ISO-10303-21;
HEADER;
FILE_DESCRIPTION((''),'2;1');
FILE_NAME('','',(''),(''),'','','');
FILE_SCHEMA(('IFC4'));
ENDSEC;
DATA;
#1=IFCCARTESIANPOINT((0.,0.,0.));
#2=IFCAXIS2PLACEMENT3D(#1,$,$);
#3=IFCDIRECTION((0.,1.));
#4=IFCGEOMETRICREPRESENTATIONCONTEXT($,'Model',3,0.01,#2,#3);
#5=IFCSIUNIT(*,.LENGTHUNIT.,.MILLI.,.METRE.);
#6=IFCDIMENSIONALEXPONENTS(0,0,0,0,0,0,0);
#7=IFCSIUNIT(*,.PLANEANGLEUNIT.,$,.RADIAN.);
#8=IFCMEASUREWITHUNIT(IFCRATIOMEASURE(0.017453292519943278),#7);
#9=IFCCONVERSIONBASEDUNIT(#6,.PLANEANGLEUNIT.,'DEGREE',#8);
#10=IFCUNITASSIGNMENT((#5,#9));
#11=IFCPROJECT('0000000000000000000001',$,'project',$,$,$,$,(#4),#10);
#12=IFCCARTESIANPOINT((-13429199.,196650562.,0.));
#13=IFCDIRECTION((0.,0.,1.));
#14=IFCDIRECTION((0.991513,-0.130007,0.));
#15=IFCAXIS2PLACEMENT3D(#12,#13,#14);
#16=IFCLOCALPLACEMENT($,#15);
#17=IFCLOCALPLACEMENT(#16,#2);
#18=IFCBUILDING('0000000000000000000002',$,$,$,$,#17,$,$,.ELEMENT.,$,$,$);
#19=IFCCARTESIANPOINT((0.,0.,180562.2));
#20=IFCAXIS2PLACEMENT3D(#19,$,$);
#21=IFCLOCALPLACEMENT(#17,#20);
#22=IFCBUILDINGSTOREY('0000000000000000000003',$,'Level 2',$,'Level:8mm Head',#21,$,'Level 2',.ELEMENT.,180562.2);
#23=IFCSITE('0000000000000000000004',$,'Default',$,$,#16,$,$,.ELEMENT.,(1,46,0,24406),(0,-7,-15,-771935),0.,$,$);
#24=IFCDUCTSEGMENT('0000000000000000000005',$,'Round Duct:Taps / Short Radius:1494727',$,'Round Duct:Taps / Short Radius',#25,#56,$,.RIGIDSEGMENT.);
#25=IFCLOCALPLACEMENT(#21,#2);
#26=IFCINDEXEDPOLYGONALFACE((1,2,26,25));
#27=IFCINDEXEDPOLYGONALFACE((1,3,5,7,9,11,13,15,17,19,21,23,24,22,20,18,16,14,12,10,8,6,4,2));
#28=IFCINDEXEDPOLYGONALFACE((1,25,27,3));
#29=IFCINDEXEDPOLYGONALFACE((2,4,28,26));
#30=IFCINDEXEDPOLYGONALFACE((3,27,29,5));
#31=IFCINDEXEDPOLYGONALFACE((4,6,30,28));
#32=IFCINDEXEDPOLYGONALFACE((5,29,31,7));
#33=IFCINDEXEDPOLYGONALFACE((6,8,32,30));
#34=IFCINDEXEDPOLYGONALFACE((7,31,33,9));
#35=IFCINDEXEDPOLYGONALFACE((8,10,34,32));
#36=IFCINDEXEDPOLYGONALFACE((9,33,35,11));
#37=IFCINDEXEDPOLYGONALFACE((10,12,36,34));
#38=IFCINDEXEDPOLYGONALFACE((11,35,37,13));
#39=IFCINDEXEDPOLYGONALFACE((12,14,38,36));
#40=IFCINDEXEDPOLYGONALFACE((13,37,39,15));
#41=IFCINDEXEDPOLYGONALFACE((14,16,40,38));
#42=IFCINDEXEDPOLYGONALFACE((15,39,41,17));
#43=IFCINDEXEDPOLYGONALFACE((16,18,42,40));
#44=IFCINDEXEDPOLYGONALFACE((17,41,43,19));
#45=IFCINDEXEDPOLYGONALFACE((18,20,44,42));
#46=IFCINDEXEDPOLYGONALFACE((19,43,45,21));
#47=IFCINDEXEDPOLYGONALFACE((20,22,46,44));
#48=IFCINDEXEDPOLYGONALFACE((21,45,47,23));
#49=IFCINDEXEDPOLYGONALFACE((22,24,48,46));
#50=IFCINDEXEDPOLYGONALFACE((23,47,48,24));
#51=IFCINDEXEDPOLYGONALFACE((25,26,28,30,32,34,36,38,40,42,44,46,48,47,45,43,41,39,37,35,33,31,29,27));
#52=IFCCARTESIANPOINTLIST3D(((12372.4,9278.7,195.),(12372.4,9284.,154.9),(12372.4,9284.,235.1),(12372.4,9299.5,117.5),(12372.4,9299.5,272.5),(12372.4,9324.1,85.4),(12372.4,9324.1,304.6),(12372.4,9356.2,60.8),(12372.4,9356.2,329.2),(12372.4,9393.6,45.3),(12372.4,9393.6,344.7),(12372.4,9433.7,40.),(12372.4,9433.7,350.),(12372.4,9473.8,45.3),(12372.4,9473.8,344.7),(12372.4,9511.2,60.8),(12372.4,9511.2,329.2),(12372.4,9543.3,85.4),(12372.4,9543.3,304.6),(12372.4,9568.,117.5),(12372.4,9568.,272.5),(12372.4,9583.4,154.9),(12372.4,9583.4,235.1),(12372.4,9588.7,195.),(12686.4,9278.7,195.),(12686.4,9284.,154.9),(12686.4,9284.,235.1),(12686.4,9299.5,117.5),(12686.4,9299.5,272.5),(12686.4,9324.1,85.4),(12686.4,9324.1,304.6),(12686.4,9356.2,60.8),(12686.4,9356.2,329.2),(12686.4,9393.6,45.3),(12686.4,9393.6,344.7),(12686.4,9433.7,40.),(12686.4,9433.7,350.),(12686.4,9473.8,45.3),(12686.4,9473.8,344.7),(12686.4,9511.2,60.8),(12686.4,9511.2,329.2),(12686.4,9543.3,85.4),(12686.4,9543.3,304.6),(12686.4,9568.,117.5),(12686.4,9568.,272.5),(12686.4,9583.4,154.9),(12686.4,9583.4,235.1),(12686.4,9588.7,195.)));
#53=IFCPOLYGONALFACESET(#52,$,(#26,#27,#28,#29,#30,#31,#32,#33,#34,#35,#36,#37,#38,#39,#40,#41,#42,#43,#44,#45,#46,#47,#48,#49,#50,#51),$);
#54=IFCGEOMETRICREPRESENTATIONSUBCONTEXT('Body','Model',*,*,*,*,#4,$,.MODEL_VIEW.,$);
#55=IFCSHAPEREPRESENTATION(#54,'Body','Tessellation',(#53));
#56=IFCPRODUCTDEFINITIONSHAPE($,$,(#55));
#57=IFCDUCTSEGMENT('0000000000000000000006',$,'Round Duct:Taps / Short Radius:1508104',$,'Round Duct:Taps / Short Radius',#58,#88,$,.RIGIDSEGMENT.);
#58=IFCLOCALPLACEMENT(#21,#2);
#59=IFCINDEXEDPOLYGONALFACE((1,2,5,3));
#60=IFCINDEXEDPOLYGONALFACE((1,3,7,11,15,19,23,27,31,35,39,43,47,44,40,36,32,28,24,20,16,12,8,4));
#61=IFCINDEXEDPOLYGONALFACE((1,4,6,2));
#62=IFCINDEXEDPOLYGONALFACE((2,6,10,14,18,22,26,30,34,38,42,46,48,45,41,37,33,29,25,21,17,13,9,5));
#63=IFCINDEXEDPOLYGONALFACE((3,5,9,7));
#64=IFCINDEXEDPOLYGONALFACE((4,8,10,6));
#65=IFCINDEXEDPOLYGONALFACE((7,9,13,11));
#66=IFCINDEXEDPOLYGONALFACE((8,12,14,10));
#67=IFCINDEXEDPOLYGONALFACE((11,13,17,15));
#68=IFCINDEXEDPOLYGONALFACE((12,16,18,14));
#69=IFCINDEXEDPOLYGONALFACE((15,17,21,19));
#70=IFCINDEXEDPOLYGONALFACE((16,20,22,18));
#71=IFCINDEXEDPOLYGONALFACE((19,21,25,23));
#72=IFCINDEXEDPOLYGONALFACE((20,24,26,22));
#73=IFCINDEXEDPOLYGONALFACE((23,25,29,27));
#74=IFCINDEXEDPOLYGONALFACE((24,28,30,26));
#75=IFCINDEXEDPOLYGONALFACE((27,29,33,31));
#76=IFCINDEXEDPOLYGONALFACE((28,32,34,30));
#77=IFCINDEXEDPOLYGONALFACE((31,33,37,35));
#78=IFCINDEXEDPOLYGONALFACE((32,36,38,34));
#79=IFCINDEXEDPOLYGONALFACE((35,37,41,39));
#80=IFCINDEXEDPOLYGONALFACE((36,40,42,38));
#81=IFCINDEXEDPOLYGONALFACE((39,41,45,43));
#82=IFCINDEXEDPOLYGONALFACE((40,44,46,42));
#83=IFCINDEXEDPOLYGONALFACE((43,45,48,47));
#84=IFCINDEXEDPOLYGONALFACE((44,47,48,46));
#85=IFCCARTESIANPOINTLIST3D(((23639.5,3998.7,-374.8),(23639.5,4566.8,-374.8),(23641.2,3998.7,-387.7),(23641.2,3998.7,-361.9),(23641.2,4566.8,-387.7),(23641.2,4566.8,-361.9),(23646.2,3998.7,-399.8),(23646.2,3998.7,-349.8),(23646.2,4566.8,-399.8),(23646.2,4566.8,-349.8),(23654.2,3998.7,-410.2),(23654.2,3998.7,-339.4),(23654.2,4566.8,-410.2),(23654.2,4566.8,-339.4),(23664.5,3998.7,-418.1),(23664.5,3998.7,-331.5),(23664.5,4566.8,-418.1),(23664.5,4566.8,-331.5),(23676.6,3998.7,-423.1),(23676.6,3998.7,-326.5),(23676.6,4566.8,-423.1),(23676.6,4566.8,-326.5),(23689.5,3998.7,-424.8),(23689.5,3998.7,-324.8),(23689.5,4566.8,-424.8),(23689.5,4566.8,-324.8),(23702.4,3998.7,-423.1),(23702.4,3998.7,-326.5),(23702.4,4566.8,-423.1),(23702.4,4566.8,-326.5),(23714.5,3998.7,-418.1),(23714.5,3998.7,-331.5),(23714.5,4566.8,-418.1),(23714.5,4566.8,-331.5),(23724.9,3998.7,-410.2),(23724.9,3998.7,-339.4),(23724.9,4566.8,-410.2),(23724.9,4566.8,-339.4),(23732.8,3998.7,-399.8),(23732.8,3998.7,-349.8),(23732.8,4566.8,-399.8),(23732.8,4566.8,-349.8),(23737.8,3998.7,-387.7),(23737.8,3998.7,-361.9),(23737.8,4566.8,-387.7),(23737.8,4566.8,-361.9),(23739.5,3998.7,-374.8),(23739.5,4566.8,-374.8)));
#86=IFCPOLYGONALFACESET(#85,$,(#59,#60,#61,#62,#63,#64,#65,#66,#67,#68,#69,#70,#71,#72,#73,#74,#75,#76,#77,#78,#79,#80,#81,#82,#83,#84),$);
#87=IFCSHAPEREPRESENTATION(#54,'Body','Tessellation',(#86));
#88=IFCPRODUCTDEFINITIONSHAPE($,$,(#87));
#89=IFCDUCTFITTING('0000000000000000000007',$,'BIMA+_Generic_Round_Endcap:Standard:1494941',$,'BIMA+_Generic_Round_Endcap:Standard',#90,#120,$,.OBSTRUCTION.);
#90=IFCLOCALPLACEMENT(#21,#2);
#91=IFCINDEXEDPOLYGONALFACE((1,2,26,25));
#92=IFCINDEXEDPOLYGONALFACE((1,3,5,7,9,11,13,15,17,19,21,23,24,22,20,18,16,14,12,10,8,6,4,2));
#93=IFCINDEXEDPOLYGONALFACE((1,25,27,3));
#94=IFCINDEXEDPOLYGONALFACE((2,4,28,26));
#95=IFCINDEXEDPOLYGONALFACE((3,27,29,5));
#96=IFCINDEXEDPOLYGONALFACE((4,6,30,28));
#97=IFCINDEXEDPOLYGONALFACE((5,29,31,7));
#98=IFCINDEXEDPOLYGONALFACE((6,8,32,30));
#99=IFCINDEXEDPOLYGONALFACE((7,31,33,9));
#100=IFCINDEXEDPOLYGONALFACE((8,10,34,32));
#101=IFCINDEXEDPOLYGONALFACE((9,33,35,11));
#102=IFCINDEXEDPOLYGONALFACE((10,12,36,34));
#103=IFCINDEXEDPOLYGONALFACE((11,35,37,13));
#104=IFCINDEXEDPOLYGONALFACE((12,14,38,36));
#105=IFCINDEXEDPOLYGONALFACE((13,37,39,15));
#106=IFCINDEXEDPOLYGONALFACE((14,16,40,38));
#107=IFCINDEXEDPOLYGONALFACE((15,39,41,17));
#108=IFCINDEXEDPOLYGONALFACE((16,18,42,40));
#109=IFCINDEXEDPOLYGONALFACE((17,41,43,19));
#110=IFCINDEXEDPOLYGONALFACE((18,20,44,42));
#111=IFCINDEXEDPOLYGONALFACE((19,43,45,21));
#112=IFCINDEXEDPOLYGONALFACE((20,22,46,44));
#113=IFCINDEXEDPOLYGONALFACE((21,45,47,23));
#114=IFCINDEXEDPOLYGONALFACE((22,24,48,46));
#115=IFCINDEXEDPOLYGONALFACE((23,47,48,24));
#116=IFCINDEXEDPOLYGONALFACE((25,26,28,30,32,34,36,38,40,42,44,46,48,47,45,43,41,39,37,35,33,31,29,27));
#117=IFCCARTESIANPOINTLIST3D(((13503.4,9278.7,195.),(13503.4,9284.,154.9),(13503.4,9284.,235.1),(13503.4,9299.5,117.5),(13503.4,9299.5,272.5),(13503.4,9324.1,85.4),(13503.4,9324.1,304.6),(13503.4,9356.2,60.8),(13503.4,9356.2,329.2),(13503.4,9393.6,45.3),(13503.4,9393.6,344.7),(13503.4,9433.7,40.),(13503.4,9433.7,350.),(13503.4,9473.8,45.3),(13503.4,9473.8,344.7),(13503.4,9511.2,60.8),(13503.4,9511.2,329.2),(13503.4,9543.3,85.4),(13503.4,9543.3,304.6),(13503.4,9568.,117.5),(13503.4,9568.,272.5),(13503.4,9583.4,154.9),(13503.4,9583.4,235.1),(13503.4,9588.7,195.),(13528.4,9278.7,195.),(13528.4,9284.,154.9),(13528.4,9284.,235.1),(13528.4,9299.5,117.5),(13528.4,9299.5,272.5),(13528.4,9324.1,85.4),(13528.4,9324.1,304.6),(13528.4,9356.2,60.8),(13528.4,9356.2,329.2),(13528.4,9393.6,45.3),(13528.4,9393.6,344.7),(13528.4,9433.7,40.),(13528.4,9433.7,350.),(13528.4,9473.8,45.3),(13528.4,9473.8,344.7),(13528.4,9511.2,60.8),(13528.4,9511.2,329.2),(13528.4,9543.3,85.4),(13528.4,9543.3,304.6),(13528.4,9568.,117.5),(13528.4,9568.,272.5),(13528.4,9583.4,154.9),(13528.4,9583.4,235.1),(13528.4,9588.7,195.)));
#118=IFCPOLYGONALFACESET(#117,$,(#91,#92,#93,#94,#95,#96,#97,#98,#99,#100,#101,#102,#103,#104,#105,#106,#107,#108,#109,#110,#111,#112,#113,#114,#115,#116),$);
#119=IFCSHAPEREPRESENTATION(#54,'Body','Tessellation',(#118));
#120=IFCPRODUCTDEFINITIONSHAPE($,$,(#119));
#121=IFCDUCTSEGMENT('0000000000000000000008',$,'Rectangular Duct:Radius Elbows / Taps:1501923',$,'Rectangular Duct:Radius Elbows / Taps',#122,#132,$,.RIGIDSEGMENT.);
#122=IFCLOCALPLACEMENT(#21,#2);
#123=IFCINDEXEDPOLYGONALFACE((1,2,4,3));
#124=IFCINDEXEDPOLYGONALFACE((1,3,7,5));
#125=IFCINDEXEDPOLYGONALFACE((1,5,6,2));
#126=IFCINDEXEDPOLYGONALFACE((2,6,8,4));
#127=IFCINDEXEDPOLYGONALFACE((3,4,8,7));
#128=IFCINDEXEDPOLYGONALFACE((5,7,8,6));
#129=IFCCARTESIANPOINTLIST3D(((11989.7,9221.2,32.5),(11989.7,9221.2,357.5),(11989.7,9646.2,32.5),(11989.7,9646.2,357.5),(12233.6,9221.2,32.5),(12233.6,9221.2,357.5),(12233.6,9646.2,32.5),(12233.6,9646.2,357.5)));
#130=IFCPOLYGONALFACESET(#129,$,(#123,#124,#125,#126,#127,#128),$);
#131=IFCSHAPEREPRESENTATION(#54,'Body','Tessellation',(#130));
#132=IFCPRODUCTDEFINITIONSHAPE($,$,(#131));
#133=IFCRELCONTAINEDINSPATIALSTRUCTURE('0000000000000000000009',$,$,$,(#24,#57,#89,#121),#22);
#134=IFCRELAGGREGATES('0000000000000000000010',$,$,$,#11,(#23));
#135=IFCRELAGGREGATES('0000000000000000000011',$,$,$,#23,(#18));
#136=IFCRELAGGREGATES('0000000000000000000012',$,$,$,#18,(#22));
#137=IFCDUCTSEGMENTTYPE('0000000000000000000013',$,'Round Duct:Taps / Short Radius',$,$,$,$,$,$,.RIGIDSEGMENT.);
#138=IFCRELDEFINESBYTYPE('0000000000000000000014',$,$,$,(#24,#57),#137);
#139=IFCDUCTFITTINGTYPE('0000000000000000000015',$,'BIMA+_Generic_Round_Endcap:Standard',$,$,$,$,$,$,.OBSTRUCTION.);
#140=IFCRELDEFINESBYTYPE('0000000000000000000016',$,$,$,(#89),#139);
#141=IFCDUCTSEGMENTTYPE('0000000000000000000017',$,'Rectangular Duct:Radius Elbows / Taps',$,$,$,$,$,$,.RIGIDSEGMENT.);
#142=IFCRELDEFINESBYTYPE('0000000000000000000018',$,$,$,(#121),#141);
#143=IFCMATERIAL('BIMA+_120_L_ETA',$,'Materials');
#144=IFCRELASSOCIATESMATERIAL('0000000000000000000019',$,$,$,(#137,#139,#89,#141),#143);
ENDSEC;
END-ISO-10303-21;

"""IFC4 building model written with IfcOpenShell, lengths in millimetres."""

from ifc_helpers import new_model, entity, si_unit, converted_unit, direction, frame, origin, place, context, subcontext, project, spatial, arc, indexed_curve, outline, extrude, source, transform, mapped, material, type_object, type_shapes, element, save


model = new_model("IFC4")

# Units and contexts
model_context = context("Model", 3, precision=0.01, world=origin(), true_north=direction((0.0, 1.0)))
body_context = subcontext(model_context, "Body", "Model", "MODEL_VIEW")
ifc_project = project(units=[si_unit("LENGTHUNIT", "METRE", prefix="MILLI"), converted_unit("PLANEANGLEUNIT", "DEGREE", entity("IfcRatioMeasure", 0.017453292519943278), si_unit("PLANEANGLEUNIT", "RADIAN"), dimensions=[0, 0, 0, 0, 0, 0, 0])], contexts=[model_context])

# Site, building, storey
site_placement = place(None, frame((-13429199.0, 196650562.0, 0.0), z_axis=(0.0, 0.0, 1.0), x_axis=(0.991513, -0.130007, 0.0)))
site = spatial("IfcSite", under=ifc_project, at=site_placement, Name="Default", CompositionType="ELEMENT", RefLatitude=(1, 46, 0, 24406), RefLongitude=(0, -7, -15, -771935), RefElevation=0.0)
building_placement = place(site_placement, origin())
building = spatial("IfcBuilding", under=site, at=building_placement, CompositionType="ELEMENT")
storey_placement = place(building_placement, frame((0.0, 0.0, 180562.2)))
storey = spatial("IfcBuildingStorey", under=building, at=storey_placement, Name="Level 2", ObjectType="Level:8mm Head", LongName="Level 2", CompositionType="ELEMENT", Elevation=180562.2)

# Duct segments
ifc_material_1 = material(Name="BIMA+_120_L_ETA", Category="Materials")
duct_segment_type_1 = type_object("IfcDuctSegmentType", Name="Round Duct:Taps / Short Radius", PredefinedType="RIGIDSEGMENT", material=ifc_material_1)
duct_segment_1_placement = place(storey_placement, frame((12372.4, 9277.1, 38.4)))
element("IfcDuctSegment", 1, at=duct_segment_1_placement, inside=storey, type_object=duct_segment_type_1, Name="Round Duct:Taps / Short Radius:1494727", ObjectType="Round Duct:Taps / Short Radius", PredefinedType="RIGIDSEGMENT", context=body_context, shape_type="SweptSolid", body=[
    extrude(outline(indexed_curve([(155.0, 0.0), (109.6, 109.6), (0.0, 155.0), (-109.6, 109.6), (-155.0, 0.0), (-109.6, -109.6), (0.0, -155.0), (109.6, -109.6)], segments=[arc(1, 2, 3), arc(3, 4, 5), arc(5, 6, 7), arc(7, 8, 1)], self_intersect=False)), frame((0.0, 156.6, 156.6), z_axis=(1.0, 0.0, 0.0), x_axis=(0.0, -1.0, 0.0)), (0.0, 0.0, 1.0), 314.0),
])
duct_segment_2_placement = place(storey_placement, frame((23637.9, 3998.7, -323.2)))
element("IfcDuctSegment", 2, at=duct_segment_2_placement, inside=storey, type_object=duct_segment_type_1, Name="Round Duct:Taps / Short Radius:1508104", ObjectType="Round Duct:Taps / Short Radius", PredefinedType="RIGIDSEGMENT", context=body_context, shape_type="SweptSolid", body=[
    extrude(outline(indexed_curve([(50.0, 0.0), (35.4, 35.4), (0.0, 50.0), (-35.4, 35.4), (-50.0, 0.0), (-35.4, -35.4), (0.0, -50.0), (35.4, -35.4)], segments=[arc(1, 2, 3), arc(3, 4, 5), arc(5, 6, 7), arc(7, 8, 1)], self_intersect=False)), frame((51.6, 0.0, -51.6), z_axis=(0.0, 1.0, 0.0), x_axis=(-1.0, 0.0, 0.0)), (0.0, 0.0, 1.0), 568.0),
])

# Duct fitting
duct_fitting_type = type_object("IfcDuctFittingType", Name="BIMA+_Generic_Round_Endcap:Standard", PredefinedType="OBSTRUCTION", material=ifc_material_1)
shared_shape = source(origin(), body_context, "Body", "SweptSolid", [
    extrude(outline(indexed_curve([(0.0, 155.0), (-109.6, 109.6), (-155.0, 0.0), (-109.6, -109.6), (0.0, -155.0), (109.6, -109.6), (155.0, 0.0), (109.6, 109.6)], segments=[arc(1, 2, 3), arc(3, 4, 5), arc(5, 6, 7), arc(7, 8, 1)], self_intersect=False)), frame((0.0, 0.0, 0.0), z_axis=(1.0, 0.0, 0.0), x_axis=(0.0, 1.0, 0.0)), (0.0, 0.0, 1.0), 25.0),
])
type_shapes(duct_fitting_type, [shared_shape])
duct_fitting_placement = place(storey_placement, frame((13503.4, 9433.7, 195.0)))
element("IfcDuctFitting", 3, at=duct_fitting_placement, inside=storey, type_object=duct_fitting_type, material=ifc_material_1, Name="BIMA+_Generic_Round_Endcap:Standard:1494941", ObjectType="BIMA+_Generic_Round_Endcap:Standard", PredefinedType="OBSTRUCTION", context=body_context, shape_type="MappedRepresentation", body=[
    mapped(shared_shape, transform((0.0, 0.0, 0.0), scale=1.0)),
])

# Duct segment
duct_segment_type_2 = type_object("IfcDuctSegmentType", Name="Rectangular Duct:Radius Elbows / Taps", PredefinedType="RIGIDSEGMENT", material=ifc_material_1)
duct_segment_3_placement = place(storey_placement, frame((11989.7, 9221.2, 32.5)))
element("IfcDuctSegment", 4, at=duct_segment_3_placement, inside=storey, type_object=duct_segment_type_2, Name="Rectangular Duct:Radius Elbows / Taps:1501923", ObjectType="Rectangular Duct:Radius Elbows / Taps", PredefinedType="RIGIDSEGMENT", context=body_context, shape_type="SweptSolid", body=[
    extrude(outline(indexed_curve([(-121.9, -212.5), (121.9, -212.5), (121.9, 212.5), (-121.9, 212.5), (-121.9, -212.5)], self_intersect=False)), frame((121.9, 212.5, 0.0), z_axis=(0.0, 0.0, 1.0), x_axis=(-1.0, 0.0, 0.0)), (0.0, 0.0, 1.0), 325.0),
])

save(model, "model.ifc")
